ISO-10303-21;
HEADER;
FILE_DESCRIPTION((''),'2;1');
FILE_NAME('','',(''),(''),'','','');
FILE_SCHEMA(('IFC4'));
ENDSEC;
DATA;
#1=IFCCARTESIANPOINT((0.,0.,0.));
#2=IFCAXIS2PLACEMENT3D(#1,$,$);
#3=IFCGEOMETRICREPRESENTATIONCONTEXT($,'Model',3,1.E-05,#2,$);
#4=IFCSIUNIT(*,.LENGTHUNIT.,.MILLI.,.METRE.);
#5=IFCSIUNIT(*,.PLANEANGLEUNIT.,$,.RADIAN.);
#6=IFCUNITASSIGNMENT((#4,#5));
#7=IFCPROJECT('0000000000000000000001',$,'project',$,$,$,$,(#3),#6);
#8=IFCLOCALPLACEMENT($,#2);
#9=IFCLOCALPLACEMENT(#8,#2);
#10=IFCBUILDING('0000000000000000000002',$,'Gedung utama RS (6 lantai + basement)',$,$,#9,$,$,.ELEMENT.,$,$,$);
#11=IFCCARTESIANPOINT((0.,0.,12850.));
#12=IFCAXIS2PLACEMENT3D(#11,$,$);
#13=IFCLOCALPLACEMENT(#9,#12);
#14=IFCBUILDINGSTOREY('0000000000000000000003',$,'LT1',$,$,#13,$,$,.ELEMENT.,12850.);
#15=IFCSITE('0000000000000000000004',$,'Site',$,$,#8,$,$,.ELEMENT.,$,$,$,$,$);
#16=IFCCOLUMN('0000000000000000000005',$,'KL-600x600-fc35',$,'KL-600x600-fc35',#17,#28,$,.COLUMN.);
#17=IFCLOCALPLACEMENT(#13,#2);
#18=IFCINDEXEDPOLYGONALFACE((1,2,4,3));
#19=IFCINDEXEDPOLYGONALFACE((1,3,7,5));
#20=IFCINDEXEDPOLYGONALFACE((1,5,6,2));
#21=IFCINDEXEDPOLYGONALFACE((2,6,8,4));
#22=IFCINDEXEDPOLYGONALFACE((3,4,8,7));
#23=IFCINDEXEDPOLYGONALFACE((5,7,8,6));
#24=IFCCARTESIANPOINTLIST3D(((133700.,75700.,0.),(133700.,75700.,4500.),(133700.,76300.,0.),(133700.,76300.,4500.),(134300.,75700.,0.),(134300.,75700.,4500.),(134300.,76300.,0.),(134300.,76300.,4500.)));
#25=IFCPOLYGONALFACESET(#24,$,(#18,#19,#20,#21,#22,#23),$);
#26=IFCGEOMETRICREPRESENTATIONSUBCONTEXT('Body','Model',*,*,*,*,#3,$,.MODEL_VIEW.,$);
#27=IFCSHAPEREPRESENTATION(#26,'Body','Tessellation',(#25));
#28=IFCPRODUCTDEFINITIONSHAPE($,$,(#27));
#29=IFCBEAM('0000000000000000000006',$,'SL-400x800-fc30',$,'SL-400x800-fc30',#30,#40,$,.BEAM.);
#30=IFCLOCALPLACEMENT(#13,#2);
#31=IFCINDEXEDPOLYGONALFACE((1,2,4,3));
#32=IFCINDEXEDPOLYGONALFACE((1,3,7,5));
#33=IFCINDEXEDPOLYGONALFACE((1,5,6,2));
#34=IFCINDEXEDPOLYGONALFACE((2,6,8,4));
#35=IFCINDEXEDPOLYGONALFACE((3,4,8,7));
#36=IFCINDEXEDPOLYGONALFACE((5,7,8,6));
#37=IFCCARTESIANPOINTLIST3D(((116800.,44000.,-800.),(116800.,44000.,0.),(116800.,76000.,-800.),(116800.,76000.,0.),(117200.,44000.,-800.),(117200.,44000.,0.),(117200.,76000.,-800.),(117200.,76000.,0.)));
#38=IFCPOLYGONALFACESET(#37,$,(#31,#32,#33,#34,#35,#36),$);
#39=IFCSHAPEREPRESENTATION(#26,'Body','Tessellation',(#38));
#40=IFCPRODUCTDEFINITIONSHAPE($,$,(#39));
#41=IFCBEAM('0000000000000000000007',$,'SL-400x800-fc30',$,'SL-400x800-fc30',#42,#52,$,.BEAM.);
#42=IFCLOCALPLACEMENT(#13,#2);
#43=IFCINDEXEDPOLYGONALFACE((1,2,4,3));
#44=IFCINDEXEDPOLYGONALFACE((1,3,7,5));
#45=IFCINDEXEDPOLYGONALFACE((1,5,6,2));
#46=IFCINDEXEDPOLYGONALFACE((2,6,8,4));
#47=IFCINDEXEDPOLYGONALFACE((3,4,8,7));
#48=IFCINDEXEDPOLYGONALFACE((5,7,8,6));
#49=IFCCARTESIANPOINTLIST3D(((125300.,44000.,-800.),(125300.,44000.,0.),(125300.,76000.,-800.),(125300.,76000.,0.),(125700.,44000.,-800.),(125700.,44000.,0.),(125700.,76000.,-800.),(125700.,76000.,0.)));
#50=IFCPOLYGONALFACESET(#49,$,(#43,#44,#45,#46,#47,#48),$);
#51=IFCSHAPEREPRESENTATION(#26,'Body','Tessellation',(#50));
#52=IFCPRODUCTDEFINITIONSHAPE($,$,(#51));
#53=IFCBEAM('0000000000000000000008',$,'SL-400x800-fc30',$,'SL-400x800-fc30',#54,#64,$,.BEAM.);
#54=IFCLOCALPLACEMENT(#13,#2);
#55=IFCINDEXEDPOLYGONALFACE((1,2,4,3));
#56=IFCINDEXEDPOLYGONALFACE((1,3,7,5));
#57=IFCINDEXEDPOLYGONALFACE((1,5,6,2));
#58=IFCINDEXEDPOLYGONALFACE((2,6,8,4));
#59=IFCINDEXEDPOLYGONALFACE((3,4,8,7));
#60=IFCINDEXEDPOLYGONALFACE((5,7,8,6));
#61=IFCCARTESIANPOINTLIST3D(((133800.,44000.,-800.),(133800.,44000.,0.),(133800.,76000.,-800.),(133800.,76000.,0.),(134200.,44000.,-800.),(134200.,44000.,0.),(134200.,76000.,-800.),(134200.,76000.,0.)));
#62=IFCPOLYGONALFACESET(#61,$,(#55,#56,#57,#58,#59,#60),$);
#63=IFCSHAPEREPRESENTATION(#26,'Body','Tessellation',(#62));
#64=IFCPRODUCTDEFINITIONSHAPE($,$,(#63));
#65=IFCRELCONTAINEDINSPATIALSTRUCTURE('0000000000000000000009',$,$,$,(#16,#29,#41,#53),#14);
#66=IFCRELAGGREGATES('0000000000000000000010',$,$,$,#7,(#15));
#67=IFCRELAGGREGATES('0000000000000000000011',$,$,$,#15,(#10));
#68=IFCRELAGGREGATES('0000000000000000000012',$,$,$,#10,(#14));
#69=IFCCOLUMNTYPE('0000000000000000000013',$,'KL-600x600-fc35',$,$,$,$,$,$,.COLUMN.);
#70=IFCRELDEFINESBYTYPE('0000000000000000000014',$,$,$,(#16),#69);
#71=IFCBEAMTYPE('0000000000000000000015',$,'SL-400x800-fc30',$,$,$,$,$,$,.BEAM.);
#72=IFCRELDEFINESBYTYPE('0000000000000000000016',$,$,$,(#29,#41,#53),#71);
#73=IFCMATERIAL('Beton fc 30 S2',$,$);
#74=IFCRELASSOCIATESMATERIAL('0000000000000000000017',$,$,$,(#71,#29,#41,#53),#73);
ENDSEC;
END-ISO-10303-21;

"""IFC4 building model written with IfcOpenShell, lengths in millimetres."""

from ifc_helpers import new_model, si_unit, frame, origin, origin_2d, place, context, subcontext, project, spatial, rectangle, extrude, material, material_profile, profile_set, profile_usage, type_object, element, save


model = new_model("IFC4")

# Units and contexts
model_context = context("Model", 3, precision=1e-05, world=origin())
body_context = subcontext(model_context, "Body", "Model", "MODEL_VIEW")
ifc_project = project(units=[si_unit("LENGTHUNIT", "METRE", prefix="MILLI"), si_unit("PLANEANGLEUNIT", "RADIAN")], contexts=[model_context])

# Site, building, storey
site_placement = place(None, origin())
site = spatial("IfcSite", under=ifc_project, at=site_placement, Name="Site", CompositionType="ELEMENT")
building_placement = place(site_placement, origin())
building = spatial("IfcBuilding", under=site, at=building_placement, Name="Gedung utama RS (6 lantai + basement)", CompositionType="ELEMENT")
storey_placement = place(building_placement, frame((0.0, 0.0, 12850.0)))
storey = spatial("IfcBuildingStorey", under=building, at=storey_placement, Name="LT1", CompositionType="ELEMENT", Elevation=12850.0)

# Column
ifc_material_profile_1 = material_profile(None, rectangle(XDim=600.0, YDim=600.0, at=origin_2d()), Name="KL-600x600-fc35")
ifc_profile_set_1 = profile_set([ifc_material_profile_1], Name="KL-600x600-fc35")
ifc_profile_usage_1 = profile_usage(ifc_profile_set_1, cardinal=5)
column_type = type_object("IfcColumnType", Name="KL-600x600-fc35", PredefinedType="COLUMN", material=ifc_profile_set_1)
for number, where, z_axis, x_axis, name in (
    (1, (134000.0, 76000.0, 0.0), (0.0, 0.0, 1.0), (1.0, 0.0, 0.0), "KL-600x600-fc35"),
):
    element("IfcColumn", number, at=place(storey_placement, frame(where, z_axis=z_axis, x_axis=x_axis)), inside=storey, type_object=column_type, material=ifc_profile_usage_1, Name=name, ObjectType="KL-600x600-fc35", PredefinedType="COLUMN", context=body_context, shape_type="SweptSolid", body=[
        extrude(rectangle(XDim=600.0, YDim=600.0, at=origin_2d()), origin(), (0.0, 0.0, 1.0), 4500.0),
    ])

# Beams
ifc_material = material(Name="Beton fc 30 S2")
ifc_material_profile_2 = material_profile(ifc_material, rectangle(XDim=400.0, YDim=800.0, at=origin_2d()), Name="SL-400x800-fc30")
ifc_profile_set_2 = profile_set([ifc_material_profile_2], Name="SL-400x800-fc30")
ifc_profile_usage_2 = profile_usage(ifc_profile_set_2, cardinal=8)
beam_type = type_object("IfcBeamType", Name="SL-400x800-fc30", PredefinedType="BEAM", material=ifc_profile_set_2)
for number, where, name in (
    (2, (117000.0, 44000.0, -400.0), "SL-400x800-fc30"),
    (3, (125500.0, 44000.0, -400.0), "SL-400x800-fc30"),
    (4, (134000.0, 44000.0, -400.0), "SL-400x800-fc30"),
):
    element("IfcBeam", number, at=place(storey_placement, frame(where)), inside=storey, type_object=beam_type, material=ifc_profile_usage_2, Name=name, ObjectType="SL-400x800-fc30", PredefinedType="BEAM", context=body_context, shape_type="SweptSolid", body=[
        extrude(rectangle(XDim=400.0, YDim=800.0, at=origin_2d()), frame((0.0, 0.0, 0.0), z_axis=(0.0, 1.0, 0.0), x_axis=(-1.0, 0.0, 0.0)), (0.0, 0.0, 1.0), 32000.0),
    ])

save(model, "model.ifc")
